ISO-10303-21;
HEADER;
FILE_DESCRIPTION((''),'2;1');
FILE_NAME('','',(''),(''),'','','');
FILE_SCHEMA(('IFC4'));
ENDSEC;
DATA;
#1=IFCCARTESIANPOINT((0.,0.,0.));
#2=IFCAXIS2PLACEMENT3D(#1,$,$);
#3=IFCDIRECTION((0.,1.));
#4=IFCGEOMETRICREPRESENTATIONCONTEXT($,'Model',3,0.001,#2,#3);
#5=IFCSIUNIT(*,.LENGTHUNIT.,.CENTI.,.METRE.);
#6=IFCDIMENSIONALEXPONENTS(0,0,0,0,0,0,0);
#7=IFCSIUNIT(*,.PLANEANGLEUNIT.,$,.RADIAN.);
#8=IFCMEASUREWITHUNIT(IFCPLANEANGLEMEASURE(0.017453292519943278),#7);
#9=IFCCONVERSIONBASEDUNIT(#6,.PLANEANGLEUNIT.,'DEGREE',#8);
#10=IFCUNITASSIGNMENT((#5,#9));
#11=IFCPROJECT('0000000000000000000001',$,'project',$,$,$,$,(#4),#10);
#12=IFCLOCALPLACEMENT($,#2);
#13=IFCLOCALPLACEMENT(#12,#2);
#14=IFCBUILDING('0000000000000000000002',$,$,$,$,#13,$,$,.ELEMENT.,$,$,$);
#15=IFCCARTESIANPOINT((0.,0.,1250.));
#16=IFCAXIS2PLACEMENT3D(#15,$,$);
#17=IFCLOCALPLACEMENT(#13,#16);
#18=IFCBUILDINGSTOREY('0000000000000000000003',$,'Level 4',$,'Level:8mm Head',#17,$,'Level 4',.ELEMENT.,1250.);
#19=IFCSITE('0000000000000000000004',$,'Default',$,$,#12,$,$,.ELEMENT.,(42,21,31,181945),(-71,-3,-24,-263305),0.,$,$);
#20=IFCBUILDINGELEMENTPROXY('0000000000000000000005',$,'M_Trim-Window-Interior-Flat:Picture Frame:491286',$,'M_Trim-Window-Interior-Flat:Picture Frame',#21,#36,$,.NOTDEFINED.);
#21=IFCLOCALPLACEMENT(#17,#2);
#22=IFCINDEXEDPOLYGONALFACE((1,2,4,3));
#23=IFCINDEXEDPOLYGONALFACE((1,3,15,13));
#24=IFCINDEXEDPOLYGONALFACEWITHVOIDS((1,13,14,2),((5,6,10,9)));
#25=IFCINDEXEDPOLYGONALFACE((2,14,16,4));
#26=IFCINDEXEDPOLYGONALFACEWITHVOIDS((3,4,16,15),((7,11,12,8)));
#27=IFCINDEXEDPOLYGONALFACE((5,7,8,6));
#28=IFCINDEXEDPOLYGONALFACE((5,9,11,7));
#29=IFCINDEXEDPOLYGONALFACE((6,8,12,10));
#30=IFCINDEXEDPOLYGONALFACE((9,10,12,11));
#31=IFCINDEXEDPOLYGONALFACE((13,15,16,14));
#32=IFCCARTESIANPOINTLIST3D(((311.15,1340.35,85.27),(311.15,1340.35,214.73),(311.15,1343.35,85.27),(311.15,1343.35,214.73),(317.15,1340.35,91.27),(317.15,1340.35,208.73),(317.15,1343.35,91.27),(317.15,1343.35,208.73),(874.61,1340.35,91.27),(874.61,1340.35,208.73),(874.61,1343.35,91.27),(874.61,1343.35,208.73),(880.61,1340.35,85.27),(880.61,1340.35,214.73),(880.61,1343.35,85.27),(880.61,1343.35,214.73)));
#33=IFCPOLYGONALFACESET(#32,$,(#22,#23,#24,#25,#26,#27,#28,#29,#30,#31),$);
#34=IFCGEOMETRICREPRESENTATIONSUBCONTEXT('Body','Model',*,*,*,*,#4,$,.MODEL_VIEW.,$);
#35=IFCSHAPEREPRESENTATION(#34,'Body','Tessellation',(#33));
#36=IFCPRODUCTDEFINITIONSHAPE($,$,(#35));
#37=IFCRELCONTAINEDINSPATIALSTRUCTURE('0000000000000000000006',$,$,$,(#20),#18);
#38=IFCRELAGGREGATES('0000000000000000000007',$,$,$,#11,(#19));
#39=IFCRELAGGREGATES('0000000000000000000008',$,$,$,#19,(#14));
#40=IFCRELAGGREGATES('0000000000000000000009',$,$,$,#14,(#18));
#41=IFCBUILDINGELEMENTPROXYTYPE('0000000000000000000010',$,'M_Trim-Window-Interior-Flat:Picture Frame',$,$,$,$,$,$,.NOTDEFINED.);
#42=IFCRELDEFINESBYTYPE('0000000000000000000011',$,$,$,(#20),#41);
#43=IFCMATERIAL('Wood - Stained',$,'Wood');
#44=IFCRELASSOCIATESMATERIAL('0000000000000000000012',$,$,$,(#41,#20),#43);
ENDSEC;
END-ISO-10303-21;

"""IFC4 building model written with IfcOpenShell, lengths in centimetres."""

from ifc_helpers import new_model, entity, si_unit, converted_unit, direction, frame, origin, place, context, subcontext, project, spatial, indexed_curve, outline, extrude, source, transform, mapped, material, type_object, type_shapes, element, save


model = new_model("IFC4")

# Units and contexts
model_context = context("Model", 3, precision=0.001, world=origin(), true_north=direction((0.0, 1.0)))
body_context = subcontext(model_context, "Body", "Model", "MODEL_VIEW")
ifc_project = project(units=[si_unit("LENGTHUNIT", "METRE", prefix="CENTI"), converted_unit("PLANEANGLEUNIT", "DEGREE", entity("IfcPlaneAngleMeasure", 0.017453292519943278), si_unit("PLANEANGLEUNIT", "RADIAN"), dimensions=[0, 0, 0, 0, 0, 0, 0])], contexts=[model_context])

# Site, building, storey
site_placement = place(None, origin())
site = spatial("IfcSite", under=ifc_project, at=site_placement, Name="Default", CompositionType="ELEMENT", RefLatitude=(42, 21, 31, 181945), RefLongitude=(-71, -3, -24, -263305), RefElevation=0.0)
building_placement = place(site_placement, origin())
building = spatial("IfcBuilding", under=site, at=building_placement, CompositionType="ELEMENT")
storey_placement = place(building_placement, frame((0.0, 0.0, 1250.0)))
storey = spatial("IfcBuildingStorey", under=building, at=storey_placement, Name="Level 4", ObjectType="Level:8mm Head", LongName="Level 4", CompositionType="ELEMENT", Elevation=1250.0)

# Building element proxy
ifc_material_1 = material(Name="Wood - Stained", Category="Wood")
building_element_proxy_type_1 = type_object("IfcBuildingElementProxyType", Name="M_Trim-Window-Interior-Flat:Picture Frame", PredefinedType="NOTDEFINED", material=ifc_material_1)
shared_shape_1 = source(origin(), body_context, "Body", "SweptSolid", [
    extrude(outline(indexed_curve([(-284.73, -64.73), (284.73, -64.73), (284.73, 64.73), (-284.73, 64.73), (-284.73, -64.73)], self_intersect=False), holes=[indexed_curve([(-278.73, -58.73), (-278.73, 58.73), (278.73, 58.73), (278.73, -58.73), (-278.73, -58.73)], self_intersect=False)]), frame((0.0, -60.0, 0.0), z_axis=(0.0, 0.0, 1.0), x_axis=(-1.0, 0.0, 0.0)), (0.0, 0.0, 1.0), 3.0),
])
type_shapes(building_element_proxy_type_1, [shared_shape_1])
proxy_1_placement = place(storey_placement, frame((595.88, 1343.35, 210.0), z_axis=(0.0, -1.0, 0.0), x_axis=(1.0, 0.0, 0.0)))
element("IfcBuildingElementProxy", 1, at=proxy_1_placement, inside=storey, type_object=building_element_proxy_type_1, material=ifc_material_1, Name="M_Trim-Window-Interior-Flat:Picture Frame:491286", ObjectType="M_Trim-Window-Interior-Flat:Picture Frame", PredefinedType="NOTDEFINED", context=body_context, shape_type="MappedRepresentation", body=[
    mapped(shared_shape_1, transform((0.0, 0.0, 0.0), scale=1.0)),
])

save(model, "model.ifc")
